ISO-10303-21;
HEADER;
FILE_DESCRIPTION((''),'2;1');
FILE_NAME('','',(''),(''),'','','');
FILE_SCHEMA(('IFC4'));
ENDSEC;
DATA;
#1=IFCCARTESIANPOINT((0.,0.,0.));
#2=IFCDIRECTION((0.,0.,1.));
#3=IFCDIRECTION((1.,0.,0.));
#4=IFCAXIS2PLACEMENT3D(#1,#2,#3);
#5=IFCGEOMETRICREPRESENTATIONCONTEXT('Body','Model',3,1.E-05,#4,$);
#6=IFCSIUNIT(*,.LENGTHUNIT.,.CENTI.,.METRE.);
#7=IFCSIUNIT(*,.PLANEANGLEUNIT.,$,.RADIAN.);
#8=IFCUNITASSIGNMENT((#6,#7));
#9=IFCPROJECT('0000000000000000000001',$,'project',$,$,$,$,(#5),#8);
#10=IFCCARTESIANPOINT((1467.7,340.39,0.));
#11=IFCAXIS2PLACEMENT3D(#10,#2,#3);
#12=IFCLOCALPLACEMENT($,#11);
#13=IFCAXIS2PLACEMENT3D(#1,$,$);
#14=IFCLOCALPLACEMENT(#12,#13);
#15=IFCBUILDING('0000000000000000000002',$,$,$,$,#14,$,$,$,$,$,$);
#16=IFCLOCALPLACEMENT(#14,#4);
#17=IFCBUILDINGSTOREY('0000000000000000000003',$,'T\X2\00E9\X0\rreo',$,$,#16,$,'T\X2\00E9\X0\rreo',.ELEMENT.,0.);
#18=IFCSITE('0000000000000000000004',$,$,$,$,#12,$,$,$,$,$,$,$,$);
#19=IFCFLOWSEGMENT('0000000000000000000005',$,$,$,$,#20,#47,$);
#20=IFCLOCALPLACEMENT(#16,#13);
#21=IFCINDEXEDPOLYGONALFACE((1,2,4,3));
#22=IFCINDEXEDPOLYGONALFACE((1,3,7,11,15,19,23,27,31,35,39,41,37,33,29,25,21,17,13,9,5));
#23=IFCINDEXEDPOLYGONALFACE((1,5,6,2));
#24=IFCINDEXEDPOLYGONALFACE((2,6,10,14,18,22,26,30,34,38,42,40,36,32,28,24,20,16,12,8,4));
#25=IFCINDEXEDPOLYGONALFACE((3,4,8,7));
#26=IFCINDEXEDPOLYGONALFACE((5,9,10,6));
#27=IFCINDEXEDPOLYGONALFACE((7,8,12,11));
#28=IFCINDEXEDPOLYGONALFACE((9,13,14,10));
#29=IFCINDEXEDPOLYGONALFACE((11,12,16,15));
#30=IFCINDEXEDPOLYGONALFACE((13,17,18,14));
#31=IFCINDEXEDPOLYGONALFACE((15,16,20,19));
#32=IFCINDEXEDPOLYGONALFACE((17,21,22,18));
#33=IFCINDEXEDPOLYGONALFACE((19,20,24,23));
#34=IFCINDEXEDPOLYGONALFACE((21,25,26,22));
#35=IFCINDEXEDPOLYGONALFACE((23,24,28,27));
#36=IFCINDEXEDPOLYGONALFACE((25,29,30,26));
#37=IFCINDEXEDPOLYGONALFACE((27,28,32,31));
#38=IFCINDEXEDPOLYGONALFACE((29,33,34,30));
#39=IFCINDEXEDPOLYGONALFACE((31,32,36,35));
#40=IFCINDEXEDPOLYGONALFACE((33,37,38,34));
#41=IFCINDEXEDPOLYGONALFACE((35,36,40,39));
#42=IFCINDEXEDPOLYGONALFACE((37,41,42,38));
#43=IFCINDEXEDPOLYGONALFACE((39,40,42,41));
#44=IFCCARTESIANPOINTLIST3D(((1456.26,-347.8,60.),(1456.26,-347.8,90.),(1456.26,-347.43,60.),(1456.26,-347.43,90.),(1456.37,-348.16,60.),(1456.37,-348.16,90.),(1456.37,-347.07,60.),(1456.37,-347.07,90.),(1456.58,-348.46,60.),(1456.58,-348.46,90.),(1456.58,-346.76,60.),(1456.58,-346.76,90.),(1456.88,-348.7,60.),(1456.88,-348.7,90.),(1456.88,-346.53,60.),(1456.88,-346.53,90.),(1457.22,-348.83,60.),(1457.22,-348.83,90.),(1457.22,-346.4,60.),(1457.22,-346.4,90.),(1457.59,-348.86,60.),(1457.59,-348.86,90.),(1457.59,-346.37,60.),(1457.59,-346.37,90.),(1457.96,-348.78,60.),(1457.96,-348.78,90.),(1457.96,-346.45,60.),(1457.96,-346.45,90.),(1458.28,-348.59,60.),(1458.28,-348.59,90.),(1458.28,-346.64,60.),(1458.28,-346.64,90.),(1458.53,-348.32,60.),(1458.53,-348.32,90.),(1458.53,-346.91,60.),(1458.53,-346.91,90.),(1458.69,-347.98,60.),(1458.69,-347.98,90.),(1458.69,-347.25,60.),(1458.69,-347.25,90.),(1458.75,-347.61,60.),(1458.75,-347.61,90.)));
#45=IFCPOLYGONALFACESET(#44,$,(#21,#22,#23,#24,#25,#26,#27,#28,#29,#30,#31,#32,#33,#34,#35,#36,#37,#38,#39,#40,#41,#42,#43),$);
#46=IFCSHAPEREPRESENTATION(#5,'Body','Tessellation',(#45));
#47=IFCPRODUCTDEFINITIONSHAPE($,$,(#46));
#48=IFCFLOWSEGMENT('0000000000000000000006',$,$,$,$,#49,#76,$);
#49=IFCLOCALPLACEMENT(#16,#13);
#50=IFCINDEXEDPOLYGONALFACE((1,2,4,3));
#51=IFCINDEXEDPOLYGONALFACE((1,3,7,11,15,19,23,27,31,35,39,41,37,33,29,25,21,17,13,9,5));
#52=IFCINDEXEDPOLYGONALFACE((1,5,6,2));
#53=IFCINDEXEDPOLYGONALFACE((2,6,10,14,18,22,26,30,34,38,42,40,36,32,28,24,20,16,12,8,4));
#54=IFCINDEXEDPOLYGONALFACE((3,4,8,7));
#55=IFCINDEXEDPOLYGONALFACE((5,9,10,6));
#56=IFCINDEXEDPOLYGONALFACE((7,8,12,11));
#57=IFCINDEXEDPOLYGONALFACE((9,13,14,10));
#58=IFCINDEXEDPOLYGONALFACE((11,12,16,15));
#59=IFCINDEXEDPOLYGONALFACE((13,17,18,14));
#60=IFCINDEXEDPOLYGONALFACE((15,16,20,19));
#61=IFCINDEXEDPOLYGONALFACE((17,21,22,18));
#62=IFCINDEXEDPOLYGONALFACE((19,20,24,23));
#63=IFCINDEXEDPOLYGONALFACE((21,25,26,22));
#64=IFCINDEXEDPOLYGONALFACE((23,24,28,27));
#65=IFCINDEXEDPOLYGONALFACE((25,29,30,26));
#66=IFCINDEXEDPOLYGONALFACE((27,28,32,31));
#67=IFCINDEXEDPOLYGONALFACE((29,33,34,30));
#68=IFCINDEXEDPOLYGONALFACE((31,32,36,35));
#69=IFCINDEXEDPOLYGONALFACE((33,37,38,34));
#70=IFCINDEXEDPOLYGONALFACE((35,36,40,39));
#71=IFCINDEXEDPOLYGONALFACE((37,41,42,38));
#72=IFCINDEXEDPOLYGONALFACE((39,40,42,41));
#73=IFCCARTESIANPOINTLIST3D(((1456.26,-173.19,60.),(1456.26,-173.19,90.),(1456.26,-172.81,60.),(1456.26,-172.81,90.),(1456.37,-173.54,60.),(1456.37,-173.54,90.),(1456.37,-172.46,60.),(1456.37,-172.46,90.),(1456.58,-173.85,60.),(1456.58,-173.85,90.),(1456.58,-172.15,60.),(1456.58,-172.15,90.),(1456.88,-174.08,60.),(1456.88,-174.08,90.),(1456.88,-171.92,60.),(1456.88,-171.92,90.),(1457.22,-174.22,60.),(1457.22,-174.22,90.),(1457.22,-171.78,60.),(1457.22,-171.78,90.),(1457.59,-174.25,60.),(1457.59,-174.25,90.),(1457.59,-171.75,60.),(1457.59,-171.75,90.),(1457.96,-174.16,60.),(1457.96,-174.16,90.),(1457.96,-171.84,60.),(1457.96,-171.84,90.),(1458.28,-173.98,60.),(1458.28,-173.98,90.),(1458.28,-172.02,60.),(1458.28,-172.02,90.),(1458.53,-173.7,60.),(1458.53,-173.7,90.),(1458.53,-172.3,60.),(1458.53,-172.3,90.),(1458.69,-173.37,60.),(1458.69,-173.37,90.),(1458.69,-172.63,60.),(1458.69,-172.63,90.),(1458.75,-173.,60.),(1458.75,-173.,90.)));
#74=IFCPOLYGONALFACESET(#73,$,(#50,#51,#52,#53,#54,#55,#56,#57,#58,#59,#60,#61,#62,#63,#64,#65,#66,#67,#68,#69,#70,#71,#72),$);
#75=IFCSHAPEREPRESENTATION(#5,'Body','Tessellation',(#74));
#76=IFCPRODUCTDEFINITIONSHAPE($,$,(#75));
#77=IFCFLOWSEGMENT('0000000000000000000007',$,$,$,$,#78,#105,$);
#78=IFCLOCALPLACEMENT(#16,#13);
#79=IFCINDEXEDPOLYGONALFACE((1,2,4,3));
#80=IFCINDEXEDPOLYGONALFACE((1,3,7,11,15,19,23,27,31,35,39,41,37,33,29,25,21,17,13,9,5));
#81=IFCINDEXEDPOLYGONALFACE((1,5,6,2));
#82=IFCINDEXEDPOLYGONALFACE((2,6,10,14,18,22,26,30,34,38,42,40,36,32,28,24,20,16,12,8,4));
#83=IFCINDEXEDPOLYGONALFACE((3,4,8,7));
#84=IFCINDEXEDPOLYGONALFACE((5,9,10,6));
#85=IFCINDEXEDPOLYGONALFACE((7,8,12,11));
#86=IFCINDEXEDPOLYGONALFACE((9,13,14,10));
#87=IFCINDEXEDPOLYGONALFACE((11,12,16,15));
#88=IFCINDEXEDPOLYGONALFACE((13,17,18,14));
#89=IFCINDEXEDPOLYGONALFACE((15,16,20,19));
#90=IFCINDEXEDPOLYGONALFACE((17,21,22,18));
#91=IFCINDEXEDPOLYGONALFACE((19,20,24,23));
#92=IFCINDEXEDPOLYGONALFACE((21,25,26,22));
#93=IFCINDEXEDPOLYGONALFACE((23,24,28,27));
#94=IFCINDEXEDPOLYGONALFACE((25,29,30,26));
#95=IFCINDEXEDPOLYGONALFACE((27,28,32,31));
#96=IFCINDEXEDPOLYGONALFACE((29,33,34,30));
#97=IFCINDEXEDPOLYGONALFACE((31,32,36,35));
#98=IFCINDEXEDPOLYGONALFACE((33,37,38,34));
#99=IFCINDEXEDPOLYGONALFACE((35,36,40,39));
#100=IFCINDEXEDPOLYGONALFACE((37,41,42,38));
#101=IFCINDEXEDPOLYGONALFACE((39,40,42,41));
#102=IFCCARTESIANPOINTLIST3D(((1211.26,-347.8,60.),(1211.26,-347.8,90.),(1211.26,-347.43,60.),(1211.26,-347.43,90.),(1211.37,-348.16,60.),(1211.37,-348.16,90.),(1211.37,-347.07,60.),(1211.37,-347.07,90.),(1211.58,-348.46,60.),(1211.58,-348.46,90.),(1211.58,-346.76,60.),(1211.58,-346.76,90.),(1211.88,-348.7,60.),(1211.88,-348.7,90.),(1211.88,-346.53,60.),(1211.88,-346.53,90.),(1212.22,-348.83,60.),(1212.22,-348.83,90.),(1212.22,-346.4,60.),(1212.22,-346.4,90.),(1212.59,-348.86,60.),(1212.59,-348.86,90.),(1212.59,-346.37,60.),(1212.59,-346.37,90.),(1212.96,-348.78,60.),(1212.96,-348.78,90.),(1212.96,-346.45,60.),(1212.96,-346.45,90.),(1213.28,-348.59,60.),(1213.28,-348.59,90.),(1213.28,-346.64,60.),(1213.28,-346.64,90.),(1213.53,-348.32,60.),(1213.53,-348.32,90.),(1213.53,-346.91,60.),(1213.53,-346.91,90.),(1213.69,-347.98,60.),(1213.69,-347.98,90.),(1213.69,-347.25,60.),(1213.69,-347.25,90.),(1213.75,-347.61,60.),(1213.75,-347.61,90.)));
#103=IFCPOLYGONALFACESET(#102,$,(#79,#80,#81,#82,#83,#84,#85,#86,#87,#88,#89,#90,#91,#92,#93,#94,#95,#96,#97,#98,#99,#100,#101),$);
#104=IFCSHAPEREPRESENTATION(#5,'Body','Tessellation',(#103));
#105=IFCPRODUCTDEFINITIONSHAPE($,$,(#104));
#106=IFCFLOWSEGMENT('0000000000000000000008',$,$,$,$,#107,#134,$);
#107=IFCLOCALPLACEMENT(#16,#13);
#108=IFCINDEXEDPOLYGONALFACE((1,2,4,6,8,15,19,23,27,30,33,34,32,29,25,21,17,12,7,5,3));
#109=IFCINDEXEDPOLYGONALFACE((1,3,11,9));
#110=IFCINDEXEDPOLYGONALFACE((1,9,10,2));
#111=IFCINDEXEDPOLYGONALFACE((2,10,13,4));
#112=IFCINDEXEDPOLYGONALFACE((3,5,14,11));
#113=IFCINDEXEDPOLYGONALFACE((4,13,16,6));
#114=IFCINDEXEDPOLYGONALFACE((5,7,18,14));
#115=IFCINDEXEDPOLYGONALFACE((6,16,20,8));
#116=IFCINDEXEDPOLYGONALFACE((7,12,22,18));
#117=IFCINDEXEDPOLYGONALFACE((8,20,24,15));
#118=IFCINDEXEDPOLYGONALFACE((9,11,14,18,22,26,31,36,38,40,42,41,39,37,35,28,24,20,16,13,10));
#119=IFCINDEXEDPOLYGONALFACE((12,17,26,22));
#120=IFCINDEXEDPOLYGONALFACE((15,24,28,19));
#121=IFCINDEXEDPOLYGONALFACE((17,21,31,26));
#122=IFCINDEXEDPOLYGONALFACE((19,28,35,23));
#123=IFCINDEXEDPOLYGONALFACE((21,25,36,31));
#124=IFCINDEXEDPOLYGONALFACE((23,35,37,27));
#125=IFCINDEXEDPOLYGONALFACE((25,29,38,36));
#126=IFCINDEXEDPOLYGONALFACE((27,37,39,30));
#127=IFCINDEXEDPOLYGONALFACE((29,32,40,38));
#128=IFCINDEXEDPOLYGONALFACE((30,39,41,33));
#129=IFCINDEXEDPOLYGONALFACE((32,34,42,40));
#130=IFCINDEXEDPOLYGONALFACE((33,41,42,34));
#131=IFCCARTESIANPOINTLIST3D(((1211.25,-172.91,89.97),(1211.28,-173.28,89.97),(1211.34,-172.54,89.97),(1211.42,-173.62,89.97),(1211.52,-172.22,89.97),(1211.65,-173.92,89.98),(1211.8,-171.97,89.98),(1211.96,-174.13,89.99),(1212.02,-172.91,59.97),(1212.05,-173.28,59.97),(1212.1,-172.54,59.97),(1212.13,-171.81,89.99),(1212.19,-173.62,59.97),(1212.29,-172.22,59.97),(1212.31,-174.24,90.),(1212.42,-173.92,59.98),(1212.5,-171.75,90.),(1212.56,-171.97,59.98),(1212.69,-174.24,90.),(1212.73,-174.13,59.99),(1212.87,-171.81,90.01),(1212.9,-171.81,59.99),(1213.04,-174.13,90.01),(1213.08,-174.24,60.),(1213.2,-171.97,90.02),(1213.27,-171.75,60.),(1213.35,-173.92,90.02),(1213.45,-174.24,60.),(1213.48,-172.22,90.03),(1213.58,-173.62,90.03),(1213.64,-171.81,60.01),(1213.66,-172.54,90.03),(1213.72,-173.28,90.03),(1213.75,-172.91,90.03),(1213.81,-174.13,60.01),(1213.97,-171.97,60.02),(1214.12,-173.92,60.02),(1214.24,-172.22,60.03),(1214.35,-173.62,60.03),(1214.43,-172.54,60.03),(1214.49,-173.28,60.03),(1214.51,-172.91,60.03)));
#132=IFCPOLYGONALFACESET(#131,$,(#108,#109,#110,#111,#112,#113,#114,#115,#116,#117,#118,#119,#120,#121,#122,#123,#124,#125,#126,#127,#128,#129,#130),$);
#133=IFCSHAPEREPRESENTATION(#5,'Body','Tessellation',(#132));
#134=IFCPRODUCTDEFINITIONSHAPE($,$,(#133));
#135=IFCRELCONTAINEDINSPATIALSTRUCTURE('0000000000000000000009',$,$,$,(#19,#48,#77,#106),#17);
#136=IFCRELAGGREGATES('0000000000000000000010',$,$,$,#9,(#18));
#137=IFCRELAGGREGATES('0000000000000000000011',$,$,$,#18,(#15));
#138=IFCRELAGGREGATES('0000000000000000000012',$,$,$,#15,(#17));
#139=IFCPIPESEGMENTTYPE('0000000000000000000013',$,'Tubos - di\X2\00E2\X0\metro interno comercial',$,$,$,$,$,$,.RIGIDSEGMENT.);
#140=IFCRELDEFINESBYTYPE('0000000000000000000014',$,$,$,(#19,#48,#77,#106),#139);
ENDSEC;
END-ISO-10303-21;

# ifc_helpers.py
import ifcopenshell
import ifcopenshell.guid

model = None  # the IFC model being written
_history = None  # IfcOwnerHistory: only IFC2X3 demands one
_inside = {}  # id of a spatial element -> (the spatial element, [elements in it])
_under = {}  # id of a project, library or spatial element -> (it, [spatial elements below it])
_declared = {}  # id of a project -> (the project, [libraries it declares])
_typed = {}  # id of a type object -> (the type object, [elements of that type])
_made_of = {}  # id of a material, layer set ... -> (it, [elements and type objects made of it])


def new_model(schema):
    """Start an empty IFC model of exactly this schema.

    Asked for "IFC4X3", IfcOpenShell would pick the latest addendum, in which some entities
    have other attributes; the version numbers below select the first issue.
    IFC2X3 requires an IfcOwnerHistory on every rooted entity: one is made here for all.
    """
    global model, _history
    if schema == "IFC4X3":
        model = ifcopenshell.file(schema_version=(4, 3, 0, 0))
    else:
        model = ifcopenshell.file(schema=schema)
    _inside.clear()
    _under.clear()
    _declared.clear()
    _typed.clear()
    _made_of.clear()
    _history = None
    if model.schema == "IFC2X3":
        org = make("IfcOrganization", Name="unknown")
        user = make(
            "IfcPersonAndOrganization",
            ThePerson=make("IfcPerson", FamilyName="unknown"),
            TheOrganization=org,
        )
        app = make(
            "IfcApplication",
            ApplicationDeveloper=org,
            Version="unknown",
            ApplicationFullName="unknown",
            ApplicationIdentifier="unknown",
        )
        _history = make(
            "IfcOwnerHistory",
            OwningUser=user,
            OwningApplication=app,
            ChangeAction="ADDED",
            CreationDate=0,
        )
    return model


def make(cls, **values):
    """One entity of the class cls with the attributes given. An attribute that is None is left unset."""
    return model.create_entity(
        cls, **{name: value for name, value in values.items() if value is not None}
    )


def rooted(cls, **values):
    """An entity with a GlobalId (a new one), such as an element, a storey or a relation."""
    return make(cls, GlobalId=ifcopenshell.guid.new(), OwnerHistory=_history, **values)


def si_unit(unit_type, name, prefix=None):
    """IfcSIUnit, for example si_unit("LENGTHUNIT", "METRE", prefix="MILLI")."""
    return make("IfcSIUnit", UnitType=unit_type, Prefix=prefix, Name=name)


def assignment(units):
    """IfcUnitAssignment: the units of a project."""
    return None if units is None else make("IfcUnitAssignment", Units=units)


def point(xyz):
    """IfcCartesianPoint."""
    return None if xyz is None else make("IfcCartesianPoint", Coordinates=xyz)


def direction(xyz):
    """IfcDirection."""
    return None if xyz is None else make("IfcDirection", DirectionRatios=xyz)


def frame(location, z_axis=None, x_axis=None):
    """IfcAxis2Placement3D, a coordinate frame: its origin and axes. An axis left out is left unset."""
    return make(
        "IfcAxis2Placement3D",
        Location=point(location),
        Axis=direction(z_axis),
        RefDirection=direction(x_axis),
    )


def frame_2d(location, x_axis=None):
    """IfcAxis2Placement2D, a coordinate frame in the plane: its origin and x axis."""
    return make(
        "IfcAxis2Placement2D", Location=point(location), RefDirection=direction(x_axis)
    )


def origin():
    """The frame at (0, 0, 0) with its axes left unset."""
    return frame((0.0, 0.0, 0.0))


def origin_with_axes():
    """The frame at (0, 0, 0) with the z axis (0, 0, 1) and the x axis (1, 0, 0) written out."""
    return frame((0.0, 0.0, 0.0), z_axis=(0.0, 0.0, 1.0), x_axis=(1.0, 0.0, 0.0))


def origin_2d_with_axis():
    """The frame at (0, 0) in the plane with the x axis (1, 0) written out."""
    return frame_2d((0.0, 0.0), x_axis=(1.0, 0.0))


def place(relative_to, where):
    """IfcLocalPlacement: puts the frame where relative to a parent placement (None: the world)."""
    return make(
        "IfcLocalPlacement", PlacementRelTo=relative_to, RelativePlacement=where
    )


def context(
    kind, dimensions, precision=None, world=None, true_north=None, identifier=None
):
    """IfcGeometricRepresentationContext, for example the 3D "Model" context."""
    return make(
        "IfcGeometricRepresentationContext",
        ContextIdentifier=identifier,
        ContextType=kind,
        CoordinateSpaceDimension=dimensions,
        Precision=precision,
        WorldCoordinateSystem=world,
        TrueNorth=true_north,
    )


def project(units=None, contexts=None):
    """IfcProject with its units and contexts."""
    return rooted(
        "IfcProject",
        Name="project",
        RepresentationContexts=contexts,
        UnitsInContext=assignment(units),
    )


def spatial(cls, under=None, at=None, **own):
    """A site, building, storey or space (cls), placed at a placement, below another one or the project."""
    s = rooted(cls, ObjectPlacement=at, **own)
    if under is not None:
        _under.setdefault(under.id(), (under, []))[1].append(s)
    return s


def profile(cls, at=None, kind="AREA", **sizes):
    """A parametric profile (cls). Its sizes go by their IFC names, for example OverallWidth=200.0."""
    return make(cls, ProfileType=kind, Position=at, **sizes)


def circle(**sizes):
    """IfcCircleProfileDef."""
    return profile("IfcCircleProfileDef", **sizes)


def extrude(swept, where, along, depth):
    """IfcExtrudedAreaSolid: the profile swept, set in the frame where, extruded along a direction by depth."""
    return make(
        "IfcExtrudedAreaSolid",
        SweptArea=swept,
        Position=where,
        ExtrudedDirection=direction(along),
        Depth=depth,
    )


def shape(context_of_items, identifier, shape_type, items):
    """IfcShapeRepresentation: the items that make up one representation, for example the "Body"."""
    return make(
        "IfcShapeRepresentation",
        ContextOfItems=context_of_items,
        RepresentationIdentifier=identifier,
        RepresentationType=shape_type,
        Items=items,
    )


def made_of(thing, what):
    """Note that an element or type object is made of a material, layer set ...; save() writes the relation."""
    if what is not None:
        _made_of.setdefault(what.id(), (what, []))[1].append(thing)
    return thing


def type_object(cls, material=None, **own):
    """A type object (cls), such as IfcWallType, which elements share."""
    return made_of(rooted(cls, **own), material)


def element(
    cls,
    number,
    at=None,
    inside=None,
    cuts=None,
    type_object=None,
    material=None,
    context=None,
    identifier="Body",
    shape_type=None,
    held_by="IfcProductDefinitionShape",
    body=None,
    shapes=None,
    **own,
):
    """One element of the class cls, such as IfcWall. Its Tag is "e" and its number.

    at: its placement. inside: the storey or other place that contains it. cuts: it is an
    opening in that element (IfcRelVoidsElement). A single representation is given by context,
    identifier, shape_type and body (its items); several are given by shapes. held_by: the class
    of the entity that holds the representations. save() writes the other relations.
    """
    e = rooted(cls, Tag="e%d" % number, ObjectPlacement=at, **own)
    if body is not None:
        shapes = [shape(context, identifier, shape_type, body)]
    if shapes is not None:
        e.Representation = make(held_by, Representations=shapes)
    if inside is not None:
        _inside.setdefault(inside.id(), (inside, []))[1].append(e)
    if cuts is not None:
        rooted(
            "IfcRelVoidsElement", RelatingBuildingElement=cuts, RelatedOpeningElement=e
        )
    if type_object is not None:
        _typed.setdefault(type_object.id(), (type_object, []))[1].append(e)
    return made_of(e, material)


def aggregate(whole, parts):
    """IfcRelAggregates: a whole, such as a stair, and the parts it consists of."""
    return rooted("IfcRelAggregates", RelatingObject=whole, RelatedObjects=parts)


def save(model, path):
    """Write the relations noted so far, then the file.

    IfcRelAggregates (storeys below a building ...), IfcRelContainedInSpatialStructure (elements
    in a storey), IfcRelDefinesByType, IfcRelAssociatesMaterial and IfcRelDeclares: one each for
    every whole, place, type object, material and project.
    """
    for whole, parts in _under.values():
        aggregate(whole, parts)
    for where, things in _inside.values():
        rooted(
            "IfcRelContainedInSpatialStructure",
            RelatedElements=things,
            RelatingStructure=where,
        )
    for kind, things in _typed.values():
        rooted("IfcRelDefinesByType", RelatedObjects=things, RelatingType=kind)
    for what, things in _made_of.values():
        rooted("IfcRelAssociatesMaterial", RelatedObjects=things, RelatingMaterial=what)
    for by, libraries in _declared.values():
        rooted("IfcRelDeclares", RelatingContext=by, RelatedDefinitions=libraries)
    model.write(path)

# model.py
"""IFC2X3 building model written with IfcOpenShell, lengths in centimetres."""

from ifc_helpers import new_model, si_unit, frame, origin, origin_with_axes, origin_2d_with_axis, place, context, project, spatial, circle, extrude, type_object, element, save


model = new_model("IFC2X3")

# Units and contexts
model_context = context("Model", 3, precision=1e-05, world=origin_with_axes(), identifier="Body")
ifc_project = project(units=[si_unit("LENGTHUNIT", "METRE", prefix="CENTI"), si_unit("PLANEANGLEUNIT", "RADIAN")], contexts=[model_context])

# Site, building, storey
site_placement = place(None, frame((1467.7, 340.39, 0.0), z_axis=(0.0, 0.0, 1.0), x_axis=(1.0, 0.0, 0.0)))
site = spatial("IfcSite", under=ifc_project, at=site_placement)
building_placement = place(site_placement, origin())
building = spatial("IfcBuilding", under=site, at=building_placement)
storey_placement = place(building_placement, origin_with_axes())
storey = spatial("IfcBuildingStorey", under=building, at=storey_placement, Name="Térreo", LongName="Térreo", CompositionType="ELEMENT", Elevation=0.0)

# Flow segments
pipe_segment_type = type_object("IfcPipeSegmentType", Name="Tubos - diâmetro interno comercial", PredefinedType="RIGIDSEGMENT")
for number, where, z_axis, x_axis in (
    (1, (1457.5, -347.61, 90.0), (0.0, 0.0, 1.0), (1.0, 0.0, 0.0)),
    (2, (1457.5, -173.0, 90.0), (0.0, 0.0, 1.0), (1.0, 0.0, 0.0)),
    (3, (1212.5, -347.61, 90.0), (0.0, 0.0, 1.0), (1.0, 0.0, 0.0)),
):
    element("IfcFlowSegment", number, at=place(storey_placement, frame(where, z_axis=z_axis, x_axis=x_axis)), inside=storey, type_object=pipe_segment_type, context=model_context, shape_type="SolidModel", body=[
        extrude(circle(Radius=1.25, at=origin_2d_with_axis()), frame((0.0, 0.0, 0.0), z_axis=(0.0, 0.0, -1.0), x_axis=(1.0, 0.0, 0.0)), (0.0, 0.0, 1.0), 30.0),
    ])
flow_segment_1_placement = place(storey_placement, frame((1212.88, -173.0, 90.03), z_axis=(0.0, 0.0, 1.0), x_axis=(1.0, 0.0, 0.0)))
element("IfcFlowSegment", 4, at=flow_segment_1_placement, inside=storey, type_object=pipe_segment_type, context=model_context, shape_type="SolidModel", body=[
    extrude(circle(Radius=1.25, at=origin_2d_with_axis()), frame((-0.38, 0.0, -0.03), z_axis=(0.025584, 0.0, -0.999673), x_axis=(0.0, 1.0, 0.0)), (0.0, 0.0, 1.0), 30.01),
])

save(model, "model.ifc")
